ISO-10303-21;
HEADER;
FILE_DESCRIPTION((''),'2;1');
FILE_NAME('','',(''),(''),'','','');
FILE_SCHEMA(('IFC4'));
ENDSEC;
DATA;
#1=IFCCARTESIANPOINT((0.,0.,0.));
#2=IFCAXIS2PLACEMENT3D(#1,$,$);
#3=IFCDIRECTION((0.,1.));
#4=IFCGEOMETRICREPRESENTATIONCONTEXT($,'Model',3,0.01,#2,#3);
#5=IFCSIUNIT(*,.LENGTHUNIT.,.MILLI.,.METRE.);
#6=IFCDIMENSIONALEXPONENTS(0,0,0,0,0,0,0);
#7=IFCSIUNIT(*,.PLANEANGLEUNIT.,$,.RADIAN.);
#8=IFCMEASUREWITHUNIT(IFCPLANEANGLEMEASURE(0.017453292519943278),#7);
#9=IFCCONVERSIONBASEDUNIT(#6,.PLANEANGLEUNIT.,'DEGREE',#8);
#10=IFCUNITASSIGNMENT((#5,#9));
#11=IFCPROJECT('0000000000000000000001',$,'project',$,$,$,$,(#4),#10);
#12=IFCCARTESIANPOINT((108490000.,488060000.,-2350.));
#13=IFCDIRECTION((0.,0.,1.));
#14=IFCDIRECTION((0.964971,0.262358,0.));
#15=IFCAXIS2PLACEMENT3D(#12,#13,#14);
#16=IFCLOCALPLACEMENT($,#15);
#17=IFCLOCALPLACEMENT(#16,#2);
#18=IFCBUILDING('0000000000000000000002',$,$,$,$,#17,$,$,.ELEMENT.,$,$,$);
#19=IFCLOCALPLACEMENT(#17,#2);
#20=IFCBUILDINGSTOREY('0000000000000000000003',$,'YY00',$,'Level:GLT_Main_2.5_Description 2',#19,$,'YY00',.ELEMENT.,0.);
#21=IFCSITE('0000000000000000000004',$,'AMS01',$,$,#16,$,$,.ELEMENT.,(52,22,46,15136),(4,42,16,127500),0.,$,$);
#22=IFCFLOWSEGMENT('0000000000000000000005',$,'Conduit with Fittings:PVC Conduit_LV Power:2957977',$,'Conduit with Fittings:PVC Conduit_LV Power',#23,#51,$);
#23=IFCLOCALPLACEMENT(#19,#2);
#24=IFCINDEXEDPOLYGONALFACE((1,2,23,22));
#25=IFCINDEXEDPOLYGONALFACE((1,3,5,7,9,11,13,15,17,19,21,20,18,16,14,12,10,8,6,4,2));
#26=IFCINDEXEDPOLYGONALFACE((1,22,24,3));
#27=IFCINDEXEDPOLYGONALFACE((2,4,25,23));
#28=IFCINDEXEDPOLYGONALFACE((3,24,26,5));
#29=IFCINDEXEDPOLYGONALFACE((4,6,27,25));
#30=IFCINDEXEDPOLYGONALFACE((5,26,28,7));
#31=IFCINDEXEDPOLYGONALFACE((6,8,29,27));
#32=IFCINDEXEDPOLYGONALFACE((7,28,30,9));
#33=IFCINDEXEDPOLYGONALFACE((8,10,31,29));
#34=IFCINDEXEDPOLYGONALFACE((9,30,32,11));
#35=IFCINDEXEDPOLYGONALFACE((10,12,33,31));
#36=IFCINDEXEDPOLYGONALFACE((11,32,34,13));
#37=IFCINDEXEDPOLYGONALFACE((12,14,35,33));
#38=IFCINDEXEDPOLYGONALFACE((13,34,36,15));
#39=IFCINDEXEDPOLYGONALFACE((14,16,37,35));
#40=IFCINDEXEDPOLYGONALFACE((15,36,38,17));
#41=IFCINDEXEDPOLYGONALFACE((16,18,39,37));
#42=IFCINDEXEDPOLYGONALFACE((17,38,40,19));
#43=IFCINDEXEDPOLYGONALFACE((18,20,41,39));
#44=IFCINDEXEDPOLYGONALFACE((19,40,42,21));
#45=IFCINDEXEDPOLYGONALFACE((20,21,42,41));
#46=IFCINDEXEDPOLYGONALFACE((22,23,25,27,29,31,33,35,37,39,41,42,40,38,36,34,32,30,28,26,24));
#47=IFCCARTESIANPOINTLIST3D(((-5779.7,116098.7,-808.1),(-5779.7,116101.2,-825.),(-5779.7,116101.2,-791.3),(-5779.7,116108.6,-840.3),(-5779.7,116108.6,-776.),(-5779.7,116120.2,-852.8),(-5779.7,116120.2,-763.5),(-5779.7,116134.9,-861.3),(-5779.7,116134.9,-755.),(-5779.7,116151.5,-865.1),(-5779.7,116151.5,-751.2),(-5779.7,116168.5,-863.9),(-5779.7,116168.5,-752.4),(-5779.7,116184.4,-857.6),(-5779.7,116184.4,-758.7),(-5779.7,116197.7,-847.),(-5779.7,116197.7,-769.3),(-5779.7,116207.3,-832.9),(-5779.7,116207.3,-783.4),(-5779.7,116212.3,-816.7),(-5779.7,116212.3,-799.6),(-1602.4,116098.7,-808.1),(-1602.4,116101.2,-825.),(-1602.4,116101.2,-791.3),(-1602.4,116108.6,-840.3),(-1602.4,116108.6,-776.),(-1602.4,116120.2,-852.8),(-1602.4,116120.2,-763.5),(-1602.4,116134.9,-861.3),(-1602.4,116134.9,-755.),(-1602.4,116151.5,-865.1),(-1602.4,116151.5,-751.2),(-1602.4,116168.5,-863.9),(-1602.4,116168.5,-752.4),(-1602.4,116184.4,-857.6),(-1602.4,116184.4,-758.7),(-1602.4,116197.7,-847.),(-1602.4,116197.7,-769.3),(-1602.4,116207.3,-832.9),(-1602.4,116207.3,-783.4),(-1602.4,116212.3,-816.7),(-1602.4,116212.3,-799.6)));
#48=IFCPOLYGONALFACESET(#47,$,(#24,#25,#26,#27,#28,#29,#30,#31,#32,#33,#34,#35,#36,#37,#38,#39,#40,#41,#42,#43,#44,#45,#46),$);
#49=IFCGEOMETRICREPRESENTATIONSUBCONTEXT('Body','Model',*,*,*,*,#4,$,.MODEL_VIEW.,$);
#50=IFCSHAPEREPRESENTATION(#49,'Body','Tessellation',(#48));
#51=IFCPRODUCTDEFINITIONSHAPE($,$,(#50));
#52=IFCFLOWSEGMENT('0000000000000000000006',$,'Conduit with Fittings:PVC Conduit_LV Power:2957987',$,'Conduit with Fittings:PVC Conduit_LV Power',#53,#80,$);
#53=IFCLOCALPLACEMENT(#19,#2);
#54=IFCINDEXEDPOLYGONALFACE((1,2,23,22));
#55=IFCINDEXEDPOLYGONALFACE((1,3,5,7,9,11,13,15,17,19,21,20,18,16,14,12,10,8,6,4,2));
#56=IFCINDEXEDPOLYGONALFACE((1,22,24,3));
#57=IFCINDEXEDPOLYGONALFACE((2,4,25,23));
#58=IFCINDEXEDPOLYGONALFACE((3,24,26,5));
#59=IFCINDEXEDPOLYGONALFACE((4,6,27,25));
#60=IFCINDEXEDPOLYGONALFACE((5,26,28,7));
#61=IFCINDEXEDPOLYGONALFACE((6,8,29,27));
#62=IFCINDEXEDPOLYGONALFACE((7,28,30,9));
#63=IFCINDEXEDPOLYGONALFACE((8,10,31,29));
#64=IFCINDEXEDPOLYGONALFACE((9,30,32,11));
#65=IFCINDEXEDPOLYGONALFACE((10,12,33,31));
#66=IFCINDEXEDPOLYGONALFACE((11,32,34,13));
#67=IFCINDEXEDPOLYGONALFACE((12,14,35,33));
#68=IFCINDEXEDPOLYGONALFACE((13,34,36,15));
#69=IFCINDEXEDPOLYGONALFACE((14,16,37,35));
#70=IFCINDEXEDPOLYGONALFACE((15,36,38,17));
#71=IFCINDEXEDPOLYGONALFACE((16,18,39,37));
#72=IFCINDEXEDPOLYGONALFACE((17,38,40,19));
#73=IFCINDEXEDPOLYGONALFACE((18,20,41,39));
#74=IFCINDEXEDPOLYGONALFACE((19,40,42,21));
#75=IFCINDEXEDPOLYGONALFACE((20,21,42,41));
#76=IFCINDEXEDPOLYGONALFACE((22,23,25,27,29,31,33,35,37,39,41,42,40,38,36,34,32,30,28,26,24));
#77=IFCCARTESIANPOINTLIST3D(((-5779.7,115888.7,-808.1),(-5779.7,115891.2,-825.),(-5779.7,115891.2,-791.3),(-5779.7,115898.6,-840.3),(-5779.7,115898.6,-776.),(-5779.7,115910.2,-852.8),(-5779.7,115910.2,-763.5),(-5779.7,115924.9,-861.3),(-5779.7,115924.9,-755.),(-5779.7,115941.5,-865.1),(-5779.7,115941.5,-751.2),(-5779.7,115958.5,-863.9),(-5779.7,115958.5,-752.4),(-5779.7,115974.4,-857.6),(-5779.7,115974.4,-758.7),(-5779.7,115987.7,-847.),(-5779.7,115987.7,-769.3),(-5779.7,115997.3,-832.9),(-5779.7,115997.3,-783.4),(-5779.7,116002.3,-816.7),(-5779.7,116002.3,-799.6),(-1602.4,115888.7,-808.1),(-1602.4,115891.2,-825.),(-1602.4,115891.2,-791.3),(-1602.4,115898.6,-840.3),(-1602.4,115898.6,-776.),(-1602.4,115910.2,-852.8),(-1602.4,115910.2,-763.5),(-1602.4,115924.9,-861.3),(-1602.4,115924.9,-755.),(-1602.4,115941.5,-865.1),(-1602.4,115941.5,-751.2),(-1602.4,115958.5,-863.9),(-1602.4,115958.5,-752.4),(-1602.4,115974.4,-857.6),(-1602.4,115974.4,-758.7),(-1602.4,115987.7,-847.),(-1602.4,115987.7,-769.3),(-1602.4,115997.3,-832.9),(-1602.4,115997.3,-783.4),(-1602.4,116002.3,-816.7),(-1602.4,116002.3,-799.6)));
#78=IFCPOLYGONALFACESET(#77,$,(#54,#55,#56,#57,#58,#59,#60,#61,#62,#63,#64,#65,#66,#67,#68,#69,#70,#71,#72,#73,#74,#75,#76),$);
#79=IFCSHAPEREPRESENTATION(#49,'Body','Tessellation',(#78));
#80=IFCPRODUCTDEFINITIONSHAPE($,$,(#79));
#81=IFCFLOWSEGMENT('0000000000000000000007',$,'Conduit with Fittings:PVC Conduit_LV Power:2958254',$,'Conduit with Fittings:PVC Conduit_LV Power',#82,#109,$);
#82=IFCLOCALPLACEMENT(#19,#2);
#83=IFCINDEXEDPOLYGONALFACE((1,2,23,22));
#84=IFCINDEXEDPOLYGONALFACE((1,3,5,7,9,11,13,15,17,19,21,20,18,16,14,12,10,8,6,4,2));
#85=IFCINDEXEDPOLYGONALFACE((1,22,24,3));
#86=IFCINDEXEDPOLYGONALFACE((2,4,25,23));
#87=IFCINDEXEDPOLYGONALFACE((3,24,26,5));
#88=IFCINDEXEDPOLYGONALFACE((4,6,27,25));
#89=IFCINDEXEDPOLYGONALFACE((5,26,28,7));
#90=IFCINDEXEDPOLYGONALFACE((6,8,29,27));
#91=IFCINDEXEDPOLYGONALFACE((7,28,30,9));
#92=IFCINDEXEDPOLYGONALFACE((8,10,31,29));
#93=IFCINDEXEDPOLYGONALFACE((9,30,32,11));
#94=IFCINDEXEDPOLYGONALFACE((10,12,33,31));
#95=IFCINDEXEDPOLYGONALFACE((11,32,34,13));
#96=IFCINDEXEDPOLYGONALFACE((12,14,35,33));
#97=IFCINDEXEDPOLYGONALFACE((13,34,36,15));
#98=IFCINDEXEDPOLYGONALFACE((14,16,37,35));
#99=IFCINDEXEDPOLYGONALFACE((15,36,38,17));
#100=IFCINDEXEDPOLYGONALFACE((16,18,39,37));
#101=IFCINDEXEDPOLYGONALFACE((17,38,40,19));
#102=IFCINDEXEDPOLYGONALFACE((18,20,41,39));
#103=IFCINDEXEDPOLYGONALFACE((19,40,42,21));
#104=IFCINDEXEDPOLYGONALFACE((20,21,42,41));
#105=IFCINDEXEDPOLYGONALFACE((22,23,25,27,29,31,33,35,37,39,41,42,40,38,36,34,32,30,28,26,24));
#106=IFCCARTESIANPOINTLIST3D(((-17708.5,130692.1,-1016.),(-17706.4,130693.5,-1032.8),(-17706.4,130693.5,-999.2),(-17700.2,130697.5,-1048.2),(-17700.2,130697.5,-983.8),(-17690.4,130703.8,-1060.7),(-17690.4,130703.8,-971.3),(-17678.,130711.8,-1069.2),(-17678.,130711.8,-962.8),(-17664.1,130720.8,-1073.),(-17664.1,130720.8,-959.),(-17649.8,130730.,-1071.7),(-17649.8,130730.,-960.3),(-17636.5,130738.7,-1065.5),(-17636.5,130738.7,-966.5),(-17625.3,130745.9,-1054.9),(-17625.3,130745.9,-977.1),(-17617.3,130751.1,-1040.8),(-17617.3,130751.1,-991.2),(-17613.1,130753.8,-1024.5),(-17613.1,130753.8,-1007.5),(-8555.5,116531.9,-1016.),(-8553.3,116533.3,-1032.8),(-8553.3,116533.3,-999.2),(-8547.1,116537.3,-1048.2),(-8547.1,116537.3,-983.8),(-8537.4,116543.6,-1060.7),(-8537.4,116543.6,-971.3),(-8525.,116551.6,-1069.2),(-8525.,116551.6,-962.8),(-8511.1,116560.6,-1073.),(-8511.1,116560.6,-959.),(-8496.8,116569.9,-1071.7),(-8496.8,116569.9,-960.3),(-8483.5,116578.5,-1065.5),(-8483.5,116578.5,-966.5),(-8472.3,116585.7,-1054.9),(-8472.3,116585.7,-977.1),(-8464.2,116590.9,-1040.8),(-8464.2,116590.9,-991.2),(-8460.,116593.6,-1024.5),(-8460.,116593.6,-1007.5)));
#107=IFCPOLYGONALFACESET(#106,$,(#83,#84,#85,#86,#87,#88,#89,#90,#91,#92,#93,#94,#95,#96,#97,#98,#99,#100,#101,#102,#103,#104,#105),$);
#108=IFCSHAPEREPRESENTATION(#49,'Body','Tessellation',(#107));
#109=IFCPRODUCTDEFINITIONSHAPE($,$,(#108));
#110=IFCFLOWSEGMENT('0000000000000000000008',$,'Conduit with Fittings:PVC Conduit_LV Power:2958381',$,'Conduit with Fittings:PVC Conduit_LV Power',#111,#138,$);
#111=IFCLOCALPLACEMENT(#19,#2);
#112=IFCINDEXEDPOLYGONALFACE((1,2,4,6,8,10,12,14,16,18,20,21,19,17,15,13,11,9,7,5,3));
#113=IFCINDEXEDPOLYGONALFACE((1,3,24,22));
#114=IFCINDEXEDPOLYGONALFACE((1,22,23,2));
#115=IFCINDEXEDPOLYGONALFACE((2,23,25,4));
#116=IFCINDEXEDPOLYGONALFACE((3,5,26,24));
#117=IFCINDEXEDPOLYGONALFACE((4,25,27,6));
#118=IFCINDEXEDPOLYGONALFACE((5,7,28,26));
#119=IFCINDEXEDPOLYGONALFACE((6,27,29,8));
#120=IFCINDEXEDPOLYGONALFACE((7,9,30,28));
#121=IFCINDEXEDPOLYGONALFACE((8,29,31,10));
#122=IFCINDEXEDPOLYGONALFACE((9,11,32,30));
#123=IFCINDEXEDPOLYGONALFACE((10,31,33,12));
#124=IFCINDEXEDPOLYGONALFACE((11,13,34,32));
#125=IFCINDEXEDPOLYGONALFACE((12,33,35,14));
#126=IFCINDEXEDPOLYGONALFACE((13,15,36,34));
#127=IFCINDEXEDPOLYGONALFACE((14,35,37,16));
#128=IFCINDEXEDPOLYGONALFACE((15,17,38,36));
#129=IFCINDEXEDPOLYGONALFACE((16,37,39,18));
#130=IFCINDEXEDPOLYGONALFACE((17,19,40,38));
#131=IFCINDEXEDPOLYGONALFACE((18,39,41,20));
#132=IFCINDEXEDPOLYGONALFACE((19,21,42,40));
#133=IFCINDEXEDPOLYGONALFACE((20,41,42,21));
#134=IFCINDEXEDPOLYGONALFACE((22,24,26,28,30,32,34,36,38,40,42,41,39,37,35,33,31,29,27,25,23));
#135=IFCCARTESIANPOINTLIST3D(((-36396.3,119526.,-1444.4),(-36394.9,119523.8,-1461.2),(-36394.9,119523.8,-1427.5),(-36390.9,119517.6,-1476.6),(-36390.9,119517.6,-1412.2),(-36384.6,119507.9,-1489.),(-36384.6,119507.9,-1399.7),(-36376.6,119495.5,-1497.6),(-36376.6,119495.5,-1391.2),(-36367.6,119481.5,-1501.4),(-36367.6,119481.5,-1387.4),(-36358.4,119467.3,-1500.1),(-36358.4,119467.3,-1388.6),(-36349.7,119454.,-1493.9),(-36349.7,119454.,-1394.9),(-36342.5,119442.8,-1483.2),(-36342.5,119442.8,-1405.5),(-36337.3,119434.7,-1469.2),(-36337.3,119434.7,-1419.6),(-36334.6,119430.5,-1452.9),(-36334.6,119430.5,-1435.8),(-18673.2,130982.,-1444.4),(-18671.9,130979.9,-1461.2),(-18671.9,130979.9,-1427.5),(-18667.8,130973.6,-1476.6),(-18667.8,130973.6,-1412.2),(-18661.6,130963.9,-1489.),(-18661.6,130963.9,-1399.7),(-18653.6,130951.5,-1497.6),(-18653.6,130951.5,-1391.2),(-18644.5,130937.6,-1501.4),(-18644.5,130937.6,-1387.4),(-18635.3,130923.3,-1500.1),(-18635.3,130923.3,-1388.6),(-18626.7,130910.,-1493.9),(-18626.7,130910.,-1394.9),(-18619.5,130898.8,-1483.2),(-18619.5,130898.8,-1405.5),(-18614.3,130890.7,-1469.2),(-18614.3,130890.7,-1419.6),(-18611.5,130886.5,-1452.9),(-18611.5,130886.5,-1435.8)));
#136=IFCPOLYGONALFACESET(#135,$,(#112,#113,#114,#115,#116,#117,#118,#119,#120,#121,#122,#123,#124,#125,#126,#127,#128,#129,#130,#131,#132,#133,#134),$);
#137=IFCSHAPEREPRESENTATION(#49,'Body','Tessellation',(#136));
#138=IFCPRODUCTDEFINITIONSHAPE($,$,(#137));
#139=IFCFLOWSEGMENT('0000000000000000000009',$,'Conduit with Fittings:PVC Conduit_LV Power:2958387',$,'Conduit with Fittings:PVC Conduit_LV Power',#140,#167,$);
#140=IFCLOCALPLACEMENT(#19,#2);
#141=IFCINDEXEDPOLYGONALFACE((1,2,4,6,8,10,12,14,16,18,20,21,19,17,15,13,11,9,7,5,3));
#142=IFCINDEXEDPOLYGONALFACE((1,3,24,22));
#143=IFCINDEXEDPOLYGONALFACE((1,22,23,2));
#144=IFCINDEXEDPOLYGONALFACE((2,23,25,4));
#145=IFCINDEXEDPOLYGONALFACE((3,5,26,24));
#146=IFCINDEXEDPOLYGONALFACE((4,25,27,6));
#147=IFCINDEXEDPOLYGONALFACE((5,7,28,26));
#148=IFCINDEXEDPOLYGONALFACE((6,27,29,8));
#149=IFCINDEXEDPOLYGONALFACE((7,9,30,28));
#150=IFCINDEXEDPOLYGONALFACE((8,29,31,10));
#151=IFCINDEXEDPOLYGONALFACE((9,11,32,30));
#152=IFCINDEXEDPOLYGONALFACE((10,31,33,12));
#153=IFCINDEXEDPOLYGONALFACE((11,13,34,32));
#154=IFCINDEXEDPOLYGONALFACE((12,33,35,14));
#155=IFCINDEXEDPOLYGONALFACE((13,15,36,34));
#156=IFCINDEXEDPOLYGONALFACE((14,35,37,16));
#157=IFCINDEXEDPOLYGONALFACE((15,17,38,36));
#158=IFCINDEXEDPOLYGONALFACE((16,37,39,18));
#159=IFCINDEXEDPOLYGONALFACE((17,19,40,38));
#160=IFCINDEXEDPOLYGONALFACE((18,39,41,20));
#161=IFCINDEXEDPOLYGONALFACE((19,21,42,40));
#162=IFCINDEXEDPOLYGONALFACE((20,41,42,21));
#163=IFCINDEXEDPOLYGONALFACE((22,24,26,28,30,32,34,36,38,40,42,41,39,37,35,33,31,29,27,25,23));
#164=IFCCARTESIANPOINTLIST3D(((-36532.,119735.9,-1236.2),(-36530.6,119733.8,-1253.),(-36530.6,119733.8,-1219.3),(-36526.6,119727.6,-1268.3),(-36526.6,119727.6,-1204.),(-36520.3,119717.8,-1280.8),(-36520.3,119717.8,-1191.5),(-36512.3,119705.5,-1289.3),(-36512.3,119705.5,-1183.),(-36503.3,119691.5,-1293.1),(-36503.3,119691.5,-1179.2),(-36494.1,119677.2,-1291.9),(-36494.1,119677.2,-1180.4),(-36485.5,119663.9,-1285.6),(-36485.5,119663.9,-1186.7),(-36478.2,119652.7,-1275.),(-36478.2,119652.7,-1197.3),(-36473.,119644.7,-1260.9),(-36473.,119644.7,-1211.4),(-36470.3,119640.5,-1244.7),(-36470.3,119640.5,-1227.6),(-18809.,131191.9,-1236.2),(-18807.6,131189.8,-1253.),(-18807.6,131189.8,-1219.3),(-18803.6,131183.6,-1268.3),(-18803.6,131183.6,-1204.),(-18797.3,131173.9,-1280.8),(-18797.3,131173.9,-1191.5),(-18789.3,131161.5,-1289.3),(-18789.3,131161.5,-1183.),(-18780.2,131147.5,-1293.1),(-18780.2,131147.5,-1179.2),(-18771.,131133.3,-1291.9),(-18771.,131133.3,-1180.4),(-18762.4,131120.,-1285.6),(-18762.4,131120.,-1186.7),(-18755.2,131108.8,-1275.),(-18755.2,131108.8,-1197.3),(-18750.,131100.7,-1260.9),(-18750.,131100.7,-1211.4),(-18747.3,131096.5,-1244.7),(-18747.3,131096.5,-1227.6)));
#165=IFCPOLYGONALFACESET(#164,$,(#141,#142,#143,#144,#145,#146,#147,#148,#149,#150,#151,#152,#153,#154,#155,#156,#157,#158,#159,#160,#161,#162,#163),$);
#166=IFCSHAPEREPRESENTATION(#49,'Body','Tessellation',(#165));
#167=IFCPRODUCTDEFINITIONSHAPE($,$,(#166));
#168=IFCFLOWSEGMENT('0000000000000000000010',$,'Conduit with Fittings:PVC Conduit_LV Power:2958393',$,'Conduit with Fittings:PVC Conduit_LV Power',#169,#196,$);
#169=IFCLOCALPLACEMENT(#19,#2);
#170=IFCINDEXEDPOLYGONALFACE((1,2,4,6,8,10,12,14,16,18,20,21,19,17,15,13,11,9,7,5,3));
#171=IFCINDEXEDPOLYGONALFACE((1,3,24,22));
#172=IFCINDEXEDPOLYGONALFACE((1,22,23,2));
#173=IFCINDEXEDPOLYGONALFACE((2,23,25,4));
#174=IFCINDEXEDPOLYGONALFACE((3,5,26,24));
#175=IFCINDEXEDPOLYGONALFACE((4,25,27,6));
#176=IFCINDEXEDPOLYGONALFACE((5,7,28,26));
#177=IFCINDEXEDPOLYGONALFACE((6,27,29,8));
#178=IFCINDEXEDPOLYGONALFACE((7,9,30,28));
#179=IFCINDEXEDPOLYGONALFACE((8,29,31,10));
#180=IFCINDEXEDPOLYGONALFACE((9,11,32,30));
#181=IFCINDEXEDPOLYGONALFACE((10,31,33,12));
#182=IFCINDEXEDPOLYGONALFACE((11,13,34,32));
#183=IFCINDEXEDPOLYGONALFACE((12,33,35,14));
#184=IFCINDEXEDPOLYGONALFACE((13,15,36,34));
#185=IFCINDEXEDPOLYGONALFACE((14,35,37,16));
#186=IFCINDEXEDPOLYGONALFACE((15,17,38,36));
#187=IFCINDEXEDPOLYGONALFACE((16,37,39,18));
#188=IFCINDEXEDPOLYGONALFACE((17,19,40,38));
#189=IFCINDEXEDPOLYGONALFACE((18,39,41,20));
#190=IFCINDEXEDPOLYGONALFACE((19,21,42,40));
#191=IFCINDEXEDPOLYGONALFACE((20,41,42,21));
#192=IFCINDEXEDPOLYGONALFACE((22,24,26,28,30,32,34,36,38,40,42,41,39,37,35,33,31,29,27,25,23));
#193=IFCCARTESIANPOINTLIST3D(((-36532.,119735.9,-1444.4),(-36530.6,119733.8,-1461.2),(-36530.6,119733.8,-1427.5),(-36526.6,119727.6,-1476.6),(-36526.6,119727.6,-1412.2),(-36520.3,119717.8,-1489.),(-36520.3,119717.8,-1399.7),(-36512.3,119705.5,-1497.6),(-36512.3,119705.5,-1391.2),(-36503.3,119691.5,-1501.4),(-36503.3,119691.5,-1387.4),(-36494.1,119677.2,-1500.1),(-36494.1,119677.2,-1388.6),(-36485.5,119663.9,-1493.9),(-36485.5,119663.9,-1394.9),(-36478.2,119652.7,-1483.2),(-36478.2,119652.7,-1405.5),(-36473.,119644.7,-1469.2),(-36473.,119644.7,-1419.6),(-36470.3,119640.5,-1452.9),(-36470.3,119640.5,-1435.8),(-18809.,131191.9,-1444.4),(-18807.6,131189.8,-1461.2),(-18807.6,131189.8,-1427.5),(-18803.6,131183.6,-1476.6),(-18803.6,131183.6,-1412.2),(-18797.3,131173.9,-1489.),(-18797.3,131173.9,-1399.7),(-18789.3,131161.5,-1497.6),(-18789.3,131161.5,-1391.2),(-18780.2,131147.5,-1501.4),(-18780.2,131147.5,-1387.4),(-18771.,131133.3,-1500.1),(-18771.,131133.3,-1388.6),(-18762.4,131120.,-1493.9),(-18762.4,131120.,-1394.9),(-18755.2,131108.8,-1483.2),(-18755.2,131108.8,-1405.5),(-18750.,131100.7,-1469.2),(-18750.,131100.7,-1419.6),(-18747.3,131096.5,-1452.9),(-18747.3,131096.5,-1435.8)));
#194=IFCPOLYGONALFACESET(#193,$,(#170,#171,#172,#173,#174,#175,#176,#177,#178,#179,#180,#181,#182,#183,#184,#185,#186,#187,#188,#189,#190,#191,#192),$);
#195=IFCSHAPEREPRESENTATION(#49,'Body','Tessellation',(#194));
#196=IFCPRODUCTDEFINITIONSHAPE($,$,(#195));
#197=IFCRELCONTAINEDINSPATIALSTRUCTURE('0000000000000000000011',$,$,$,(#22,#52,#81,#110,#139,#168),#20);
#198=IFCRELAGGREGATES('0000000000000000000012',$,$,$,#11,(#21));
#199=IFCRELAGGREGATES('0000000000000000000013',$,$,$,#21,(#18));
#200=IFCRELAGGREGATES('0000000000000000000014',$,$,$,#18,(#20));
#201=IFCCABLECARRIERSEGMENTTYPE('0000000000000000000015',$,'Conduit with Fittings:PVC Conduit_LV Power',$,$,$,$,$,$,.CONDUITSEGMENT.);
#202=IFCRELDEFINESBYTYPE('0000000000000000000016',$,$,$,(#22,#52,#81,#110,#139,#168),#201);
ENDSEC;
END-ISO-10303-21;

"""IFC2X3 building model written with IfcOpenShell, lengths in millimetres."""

from ifc_helpers import new_model, entity, si_unit, converted_unit, direction, frame, frame_2d, origin, origin_2d_with_axis, place, context, subcontext, project, spatial, circle, extrude, type_object, element, save


model = new_model("IFC2X3")

# Units and contexts
model_context = context("Model", 3, precision=0.01, world=origin(), true_north=direction((0.0, 1.0)))
body_context = subcontext(model_context, "Body", "Model", "MODEL_VIEW")
ifc_project = project(units=[si_unit("LENGTHUNIT", "METRE", prefix="MILLI"), converted_unit("PLANEANGLEUNIT", "DEGREE", entity("IfcPlaneAngleMeasure", 0.017453292519943278), si_unit("PLANEANGLEUNIT", "RADIAN"), dimensions=[0, 0, 0, 0, 0, 0, 0])], contexts=[model_context])

# Site, building, storey
site_placement = place(None, frame((108490000.0, 488060000.0, -2350.0), z_axis=(0.0, 0.0, 1.0), x_axis=(0.964971, 0.262358, 0.0)))
site = spatial("IfcSite", under=ifc_project, at=site_placement, Name="AMS01", CompositionType="ELEMENT", RefLatitude=(52, 22, 46, 15136), RefLongitude=(4, 42, 16, 127500), RefElevation=0.0)
building_placement = place(site_placement, origin())
building = spatial("IfcBuilding", under=site, at=building_placement, CompositionType="ELEMENT")
storey_placement = place(building_placement, origin())
storey = spatial("IfcBuildingStorey", under=building, at=storey_placement, Name="YY00", ObjectType="Level:GLT_Main_2.5_Description 2", LongName="YY00", CompositionType="ELEMENT", Elevation=0.0)

# Flow segments
cable_carrier_segment_type = type_object("IfcCableCarrierSegmentType", Name="Conduit with Fittings:PVC Conduit_LV Power", PredefinedType="CONDUITSEGMENT")
flow_segment_1_placement = place(storey_placement, origin())
element("IfcFlowSegment", 1, at=flow_segment_1_placement, inside=storey, type_object=cable_carrier_segment_type, Name="Conduit with Fittings:PVC Conduit_LV Power:2957977", ObjectType="Conduit with Fittings:PVC Conduit_LV Power", context=body_context, shape_type="SweptSolid", body=[
    extrude(circle(Radius=57.2, at=frame_2d((0.0, 0.0), x_axis=(1.0, 0.0))), frame((-5779.7, 116155.8, -808.1), z_axis=(1.0, 0.0, 0.0), x_axis=(0.0, -1.0, 0.0)), (0.0, 0.0, 1.0), 4177.3),
])
flow_segment_2_placement = place(storey_placement, origin())
element("IfcFlowSegment", 2, at=flow_segment_2_placement, inside=storey, type_object=cable_carrier_segment_type, Name="Conduit with Fittings:PVC Conduit_LV Power:2957987", ObjectType="Conduit with Fittings:PVC Conduit_LV Power", context=body_context, shape_type="SweptSolid", body=[
    extrude(circle(Radius=57.2, at=origin_2d_with_axis()), frame((-5779.7, 115945.8, -808.1), z_axis=(1.0, 0.0, 0.0), x_axis=(0.0, -1.0, 0.0)), (0.0, 0.0, 1.0), 4177.3),
])
flow_segment_3_placement = place(storey_placement, origin())
element("IfcFlowSegment", 3, at=flow_segment_3_placement, inside=storey, type_object=cable_carrier_segment_type, Name="Conduit with Fittings:PVC Conduit_LV Power:2958254", ObjectType="Conduit with Fittings:PVC Conduit_LV Power", context=body_context, shape_type="SweptSolid", body=[
    extrude(circle(Radius=57.2, at=frame_2d((0.0, 0.0), x_axis=(1.0, 0.0))), frame((-8507.5, 116563.0, -1016.0), z_axis=(-0.542856, 0.839826, 0.0), x_axis=(-0.839826, -0.542856, 0.0)), (0.0, 0.0, 1.0), 16860.9),
])
flow_segment_4_placement = place(storey_placement, origin())
element("IfcFlowSegment", 4, at=flow_segment_4_placement, inside=storey, type_object=cable_carrier_segment_type, Name="Conduit with Fittings:PVC Conduit_LV Power:2958381", ObjectType="Conduit with Fittings:PVC Conduit_LV Power", context=body_context, shape_type="SweptSolid", body=[
    extrude(circle(Radius=57.2, at=frame_2d((0.0, 0.0), x_axis=(1.0, 0.0))), frame((-36365.3, 119478.0, -1444.4), z_axis=(0.839826, 0.542856, 0.0), x_axis=(-0.542856, 0.839826, 0.0)), (0.0, 0.0, 1.0), 21103.2),
])
flow_segment_5_placement = place(storey_placement, origin())
element("IfcFlowSegment", 5, at=flow_segment_5_placement, inside=storey, type_object=cable_carrier_segment_type, Name="Conduit with Fittings:PVC Conduit_LV Power:2958387", ObjectType="Conduit with Fittings:PVC Conduit_LV Power", context=body_context, shape_type="SweptSolid", body=[
    extrude(circle(Radius=57.2, at=frame_2d((0.0, 0.0), x_axis=(1.0, 0.0))), frame((-36501.0, 119687.9, -1236.2), z_axis=(0.839826, 0.542856, 0.0), x_axis=(-0.542856, 0.839826, 0.0)), (0.0, 0.0, 1.0), 21103.2),
])
flow_segment_6_placement = place(storey_placement, origin())
element("IfcFlowSegment", 6, at=flow_segment_6_placement, inside=storey, type_object=cable_carrier_segment_type, Name="Conduit with Fittings:PVC Conduit_LV Power:2958393", ObjectType="Conduit with Fittings:PVC Conduit_LV Power", context=body_context, shape_type="SweptSolid", body=[
    extrude(circle(Radius=57.2, at=origin_2d_with_axis()), frame((-36501.0, 119687.9, -1444.4), z_axis=(0.839826, 0.542856, 0.0), x_axis=(-0.542856, 0.839826, 0.0)), (0.0, 0.0, 1.0), 21103.2),
])

save(model, "model.ifc")
